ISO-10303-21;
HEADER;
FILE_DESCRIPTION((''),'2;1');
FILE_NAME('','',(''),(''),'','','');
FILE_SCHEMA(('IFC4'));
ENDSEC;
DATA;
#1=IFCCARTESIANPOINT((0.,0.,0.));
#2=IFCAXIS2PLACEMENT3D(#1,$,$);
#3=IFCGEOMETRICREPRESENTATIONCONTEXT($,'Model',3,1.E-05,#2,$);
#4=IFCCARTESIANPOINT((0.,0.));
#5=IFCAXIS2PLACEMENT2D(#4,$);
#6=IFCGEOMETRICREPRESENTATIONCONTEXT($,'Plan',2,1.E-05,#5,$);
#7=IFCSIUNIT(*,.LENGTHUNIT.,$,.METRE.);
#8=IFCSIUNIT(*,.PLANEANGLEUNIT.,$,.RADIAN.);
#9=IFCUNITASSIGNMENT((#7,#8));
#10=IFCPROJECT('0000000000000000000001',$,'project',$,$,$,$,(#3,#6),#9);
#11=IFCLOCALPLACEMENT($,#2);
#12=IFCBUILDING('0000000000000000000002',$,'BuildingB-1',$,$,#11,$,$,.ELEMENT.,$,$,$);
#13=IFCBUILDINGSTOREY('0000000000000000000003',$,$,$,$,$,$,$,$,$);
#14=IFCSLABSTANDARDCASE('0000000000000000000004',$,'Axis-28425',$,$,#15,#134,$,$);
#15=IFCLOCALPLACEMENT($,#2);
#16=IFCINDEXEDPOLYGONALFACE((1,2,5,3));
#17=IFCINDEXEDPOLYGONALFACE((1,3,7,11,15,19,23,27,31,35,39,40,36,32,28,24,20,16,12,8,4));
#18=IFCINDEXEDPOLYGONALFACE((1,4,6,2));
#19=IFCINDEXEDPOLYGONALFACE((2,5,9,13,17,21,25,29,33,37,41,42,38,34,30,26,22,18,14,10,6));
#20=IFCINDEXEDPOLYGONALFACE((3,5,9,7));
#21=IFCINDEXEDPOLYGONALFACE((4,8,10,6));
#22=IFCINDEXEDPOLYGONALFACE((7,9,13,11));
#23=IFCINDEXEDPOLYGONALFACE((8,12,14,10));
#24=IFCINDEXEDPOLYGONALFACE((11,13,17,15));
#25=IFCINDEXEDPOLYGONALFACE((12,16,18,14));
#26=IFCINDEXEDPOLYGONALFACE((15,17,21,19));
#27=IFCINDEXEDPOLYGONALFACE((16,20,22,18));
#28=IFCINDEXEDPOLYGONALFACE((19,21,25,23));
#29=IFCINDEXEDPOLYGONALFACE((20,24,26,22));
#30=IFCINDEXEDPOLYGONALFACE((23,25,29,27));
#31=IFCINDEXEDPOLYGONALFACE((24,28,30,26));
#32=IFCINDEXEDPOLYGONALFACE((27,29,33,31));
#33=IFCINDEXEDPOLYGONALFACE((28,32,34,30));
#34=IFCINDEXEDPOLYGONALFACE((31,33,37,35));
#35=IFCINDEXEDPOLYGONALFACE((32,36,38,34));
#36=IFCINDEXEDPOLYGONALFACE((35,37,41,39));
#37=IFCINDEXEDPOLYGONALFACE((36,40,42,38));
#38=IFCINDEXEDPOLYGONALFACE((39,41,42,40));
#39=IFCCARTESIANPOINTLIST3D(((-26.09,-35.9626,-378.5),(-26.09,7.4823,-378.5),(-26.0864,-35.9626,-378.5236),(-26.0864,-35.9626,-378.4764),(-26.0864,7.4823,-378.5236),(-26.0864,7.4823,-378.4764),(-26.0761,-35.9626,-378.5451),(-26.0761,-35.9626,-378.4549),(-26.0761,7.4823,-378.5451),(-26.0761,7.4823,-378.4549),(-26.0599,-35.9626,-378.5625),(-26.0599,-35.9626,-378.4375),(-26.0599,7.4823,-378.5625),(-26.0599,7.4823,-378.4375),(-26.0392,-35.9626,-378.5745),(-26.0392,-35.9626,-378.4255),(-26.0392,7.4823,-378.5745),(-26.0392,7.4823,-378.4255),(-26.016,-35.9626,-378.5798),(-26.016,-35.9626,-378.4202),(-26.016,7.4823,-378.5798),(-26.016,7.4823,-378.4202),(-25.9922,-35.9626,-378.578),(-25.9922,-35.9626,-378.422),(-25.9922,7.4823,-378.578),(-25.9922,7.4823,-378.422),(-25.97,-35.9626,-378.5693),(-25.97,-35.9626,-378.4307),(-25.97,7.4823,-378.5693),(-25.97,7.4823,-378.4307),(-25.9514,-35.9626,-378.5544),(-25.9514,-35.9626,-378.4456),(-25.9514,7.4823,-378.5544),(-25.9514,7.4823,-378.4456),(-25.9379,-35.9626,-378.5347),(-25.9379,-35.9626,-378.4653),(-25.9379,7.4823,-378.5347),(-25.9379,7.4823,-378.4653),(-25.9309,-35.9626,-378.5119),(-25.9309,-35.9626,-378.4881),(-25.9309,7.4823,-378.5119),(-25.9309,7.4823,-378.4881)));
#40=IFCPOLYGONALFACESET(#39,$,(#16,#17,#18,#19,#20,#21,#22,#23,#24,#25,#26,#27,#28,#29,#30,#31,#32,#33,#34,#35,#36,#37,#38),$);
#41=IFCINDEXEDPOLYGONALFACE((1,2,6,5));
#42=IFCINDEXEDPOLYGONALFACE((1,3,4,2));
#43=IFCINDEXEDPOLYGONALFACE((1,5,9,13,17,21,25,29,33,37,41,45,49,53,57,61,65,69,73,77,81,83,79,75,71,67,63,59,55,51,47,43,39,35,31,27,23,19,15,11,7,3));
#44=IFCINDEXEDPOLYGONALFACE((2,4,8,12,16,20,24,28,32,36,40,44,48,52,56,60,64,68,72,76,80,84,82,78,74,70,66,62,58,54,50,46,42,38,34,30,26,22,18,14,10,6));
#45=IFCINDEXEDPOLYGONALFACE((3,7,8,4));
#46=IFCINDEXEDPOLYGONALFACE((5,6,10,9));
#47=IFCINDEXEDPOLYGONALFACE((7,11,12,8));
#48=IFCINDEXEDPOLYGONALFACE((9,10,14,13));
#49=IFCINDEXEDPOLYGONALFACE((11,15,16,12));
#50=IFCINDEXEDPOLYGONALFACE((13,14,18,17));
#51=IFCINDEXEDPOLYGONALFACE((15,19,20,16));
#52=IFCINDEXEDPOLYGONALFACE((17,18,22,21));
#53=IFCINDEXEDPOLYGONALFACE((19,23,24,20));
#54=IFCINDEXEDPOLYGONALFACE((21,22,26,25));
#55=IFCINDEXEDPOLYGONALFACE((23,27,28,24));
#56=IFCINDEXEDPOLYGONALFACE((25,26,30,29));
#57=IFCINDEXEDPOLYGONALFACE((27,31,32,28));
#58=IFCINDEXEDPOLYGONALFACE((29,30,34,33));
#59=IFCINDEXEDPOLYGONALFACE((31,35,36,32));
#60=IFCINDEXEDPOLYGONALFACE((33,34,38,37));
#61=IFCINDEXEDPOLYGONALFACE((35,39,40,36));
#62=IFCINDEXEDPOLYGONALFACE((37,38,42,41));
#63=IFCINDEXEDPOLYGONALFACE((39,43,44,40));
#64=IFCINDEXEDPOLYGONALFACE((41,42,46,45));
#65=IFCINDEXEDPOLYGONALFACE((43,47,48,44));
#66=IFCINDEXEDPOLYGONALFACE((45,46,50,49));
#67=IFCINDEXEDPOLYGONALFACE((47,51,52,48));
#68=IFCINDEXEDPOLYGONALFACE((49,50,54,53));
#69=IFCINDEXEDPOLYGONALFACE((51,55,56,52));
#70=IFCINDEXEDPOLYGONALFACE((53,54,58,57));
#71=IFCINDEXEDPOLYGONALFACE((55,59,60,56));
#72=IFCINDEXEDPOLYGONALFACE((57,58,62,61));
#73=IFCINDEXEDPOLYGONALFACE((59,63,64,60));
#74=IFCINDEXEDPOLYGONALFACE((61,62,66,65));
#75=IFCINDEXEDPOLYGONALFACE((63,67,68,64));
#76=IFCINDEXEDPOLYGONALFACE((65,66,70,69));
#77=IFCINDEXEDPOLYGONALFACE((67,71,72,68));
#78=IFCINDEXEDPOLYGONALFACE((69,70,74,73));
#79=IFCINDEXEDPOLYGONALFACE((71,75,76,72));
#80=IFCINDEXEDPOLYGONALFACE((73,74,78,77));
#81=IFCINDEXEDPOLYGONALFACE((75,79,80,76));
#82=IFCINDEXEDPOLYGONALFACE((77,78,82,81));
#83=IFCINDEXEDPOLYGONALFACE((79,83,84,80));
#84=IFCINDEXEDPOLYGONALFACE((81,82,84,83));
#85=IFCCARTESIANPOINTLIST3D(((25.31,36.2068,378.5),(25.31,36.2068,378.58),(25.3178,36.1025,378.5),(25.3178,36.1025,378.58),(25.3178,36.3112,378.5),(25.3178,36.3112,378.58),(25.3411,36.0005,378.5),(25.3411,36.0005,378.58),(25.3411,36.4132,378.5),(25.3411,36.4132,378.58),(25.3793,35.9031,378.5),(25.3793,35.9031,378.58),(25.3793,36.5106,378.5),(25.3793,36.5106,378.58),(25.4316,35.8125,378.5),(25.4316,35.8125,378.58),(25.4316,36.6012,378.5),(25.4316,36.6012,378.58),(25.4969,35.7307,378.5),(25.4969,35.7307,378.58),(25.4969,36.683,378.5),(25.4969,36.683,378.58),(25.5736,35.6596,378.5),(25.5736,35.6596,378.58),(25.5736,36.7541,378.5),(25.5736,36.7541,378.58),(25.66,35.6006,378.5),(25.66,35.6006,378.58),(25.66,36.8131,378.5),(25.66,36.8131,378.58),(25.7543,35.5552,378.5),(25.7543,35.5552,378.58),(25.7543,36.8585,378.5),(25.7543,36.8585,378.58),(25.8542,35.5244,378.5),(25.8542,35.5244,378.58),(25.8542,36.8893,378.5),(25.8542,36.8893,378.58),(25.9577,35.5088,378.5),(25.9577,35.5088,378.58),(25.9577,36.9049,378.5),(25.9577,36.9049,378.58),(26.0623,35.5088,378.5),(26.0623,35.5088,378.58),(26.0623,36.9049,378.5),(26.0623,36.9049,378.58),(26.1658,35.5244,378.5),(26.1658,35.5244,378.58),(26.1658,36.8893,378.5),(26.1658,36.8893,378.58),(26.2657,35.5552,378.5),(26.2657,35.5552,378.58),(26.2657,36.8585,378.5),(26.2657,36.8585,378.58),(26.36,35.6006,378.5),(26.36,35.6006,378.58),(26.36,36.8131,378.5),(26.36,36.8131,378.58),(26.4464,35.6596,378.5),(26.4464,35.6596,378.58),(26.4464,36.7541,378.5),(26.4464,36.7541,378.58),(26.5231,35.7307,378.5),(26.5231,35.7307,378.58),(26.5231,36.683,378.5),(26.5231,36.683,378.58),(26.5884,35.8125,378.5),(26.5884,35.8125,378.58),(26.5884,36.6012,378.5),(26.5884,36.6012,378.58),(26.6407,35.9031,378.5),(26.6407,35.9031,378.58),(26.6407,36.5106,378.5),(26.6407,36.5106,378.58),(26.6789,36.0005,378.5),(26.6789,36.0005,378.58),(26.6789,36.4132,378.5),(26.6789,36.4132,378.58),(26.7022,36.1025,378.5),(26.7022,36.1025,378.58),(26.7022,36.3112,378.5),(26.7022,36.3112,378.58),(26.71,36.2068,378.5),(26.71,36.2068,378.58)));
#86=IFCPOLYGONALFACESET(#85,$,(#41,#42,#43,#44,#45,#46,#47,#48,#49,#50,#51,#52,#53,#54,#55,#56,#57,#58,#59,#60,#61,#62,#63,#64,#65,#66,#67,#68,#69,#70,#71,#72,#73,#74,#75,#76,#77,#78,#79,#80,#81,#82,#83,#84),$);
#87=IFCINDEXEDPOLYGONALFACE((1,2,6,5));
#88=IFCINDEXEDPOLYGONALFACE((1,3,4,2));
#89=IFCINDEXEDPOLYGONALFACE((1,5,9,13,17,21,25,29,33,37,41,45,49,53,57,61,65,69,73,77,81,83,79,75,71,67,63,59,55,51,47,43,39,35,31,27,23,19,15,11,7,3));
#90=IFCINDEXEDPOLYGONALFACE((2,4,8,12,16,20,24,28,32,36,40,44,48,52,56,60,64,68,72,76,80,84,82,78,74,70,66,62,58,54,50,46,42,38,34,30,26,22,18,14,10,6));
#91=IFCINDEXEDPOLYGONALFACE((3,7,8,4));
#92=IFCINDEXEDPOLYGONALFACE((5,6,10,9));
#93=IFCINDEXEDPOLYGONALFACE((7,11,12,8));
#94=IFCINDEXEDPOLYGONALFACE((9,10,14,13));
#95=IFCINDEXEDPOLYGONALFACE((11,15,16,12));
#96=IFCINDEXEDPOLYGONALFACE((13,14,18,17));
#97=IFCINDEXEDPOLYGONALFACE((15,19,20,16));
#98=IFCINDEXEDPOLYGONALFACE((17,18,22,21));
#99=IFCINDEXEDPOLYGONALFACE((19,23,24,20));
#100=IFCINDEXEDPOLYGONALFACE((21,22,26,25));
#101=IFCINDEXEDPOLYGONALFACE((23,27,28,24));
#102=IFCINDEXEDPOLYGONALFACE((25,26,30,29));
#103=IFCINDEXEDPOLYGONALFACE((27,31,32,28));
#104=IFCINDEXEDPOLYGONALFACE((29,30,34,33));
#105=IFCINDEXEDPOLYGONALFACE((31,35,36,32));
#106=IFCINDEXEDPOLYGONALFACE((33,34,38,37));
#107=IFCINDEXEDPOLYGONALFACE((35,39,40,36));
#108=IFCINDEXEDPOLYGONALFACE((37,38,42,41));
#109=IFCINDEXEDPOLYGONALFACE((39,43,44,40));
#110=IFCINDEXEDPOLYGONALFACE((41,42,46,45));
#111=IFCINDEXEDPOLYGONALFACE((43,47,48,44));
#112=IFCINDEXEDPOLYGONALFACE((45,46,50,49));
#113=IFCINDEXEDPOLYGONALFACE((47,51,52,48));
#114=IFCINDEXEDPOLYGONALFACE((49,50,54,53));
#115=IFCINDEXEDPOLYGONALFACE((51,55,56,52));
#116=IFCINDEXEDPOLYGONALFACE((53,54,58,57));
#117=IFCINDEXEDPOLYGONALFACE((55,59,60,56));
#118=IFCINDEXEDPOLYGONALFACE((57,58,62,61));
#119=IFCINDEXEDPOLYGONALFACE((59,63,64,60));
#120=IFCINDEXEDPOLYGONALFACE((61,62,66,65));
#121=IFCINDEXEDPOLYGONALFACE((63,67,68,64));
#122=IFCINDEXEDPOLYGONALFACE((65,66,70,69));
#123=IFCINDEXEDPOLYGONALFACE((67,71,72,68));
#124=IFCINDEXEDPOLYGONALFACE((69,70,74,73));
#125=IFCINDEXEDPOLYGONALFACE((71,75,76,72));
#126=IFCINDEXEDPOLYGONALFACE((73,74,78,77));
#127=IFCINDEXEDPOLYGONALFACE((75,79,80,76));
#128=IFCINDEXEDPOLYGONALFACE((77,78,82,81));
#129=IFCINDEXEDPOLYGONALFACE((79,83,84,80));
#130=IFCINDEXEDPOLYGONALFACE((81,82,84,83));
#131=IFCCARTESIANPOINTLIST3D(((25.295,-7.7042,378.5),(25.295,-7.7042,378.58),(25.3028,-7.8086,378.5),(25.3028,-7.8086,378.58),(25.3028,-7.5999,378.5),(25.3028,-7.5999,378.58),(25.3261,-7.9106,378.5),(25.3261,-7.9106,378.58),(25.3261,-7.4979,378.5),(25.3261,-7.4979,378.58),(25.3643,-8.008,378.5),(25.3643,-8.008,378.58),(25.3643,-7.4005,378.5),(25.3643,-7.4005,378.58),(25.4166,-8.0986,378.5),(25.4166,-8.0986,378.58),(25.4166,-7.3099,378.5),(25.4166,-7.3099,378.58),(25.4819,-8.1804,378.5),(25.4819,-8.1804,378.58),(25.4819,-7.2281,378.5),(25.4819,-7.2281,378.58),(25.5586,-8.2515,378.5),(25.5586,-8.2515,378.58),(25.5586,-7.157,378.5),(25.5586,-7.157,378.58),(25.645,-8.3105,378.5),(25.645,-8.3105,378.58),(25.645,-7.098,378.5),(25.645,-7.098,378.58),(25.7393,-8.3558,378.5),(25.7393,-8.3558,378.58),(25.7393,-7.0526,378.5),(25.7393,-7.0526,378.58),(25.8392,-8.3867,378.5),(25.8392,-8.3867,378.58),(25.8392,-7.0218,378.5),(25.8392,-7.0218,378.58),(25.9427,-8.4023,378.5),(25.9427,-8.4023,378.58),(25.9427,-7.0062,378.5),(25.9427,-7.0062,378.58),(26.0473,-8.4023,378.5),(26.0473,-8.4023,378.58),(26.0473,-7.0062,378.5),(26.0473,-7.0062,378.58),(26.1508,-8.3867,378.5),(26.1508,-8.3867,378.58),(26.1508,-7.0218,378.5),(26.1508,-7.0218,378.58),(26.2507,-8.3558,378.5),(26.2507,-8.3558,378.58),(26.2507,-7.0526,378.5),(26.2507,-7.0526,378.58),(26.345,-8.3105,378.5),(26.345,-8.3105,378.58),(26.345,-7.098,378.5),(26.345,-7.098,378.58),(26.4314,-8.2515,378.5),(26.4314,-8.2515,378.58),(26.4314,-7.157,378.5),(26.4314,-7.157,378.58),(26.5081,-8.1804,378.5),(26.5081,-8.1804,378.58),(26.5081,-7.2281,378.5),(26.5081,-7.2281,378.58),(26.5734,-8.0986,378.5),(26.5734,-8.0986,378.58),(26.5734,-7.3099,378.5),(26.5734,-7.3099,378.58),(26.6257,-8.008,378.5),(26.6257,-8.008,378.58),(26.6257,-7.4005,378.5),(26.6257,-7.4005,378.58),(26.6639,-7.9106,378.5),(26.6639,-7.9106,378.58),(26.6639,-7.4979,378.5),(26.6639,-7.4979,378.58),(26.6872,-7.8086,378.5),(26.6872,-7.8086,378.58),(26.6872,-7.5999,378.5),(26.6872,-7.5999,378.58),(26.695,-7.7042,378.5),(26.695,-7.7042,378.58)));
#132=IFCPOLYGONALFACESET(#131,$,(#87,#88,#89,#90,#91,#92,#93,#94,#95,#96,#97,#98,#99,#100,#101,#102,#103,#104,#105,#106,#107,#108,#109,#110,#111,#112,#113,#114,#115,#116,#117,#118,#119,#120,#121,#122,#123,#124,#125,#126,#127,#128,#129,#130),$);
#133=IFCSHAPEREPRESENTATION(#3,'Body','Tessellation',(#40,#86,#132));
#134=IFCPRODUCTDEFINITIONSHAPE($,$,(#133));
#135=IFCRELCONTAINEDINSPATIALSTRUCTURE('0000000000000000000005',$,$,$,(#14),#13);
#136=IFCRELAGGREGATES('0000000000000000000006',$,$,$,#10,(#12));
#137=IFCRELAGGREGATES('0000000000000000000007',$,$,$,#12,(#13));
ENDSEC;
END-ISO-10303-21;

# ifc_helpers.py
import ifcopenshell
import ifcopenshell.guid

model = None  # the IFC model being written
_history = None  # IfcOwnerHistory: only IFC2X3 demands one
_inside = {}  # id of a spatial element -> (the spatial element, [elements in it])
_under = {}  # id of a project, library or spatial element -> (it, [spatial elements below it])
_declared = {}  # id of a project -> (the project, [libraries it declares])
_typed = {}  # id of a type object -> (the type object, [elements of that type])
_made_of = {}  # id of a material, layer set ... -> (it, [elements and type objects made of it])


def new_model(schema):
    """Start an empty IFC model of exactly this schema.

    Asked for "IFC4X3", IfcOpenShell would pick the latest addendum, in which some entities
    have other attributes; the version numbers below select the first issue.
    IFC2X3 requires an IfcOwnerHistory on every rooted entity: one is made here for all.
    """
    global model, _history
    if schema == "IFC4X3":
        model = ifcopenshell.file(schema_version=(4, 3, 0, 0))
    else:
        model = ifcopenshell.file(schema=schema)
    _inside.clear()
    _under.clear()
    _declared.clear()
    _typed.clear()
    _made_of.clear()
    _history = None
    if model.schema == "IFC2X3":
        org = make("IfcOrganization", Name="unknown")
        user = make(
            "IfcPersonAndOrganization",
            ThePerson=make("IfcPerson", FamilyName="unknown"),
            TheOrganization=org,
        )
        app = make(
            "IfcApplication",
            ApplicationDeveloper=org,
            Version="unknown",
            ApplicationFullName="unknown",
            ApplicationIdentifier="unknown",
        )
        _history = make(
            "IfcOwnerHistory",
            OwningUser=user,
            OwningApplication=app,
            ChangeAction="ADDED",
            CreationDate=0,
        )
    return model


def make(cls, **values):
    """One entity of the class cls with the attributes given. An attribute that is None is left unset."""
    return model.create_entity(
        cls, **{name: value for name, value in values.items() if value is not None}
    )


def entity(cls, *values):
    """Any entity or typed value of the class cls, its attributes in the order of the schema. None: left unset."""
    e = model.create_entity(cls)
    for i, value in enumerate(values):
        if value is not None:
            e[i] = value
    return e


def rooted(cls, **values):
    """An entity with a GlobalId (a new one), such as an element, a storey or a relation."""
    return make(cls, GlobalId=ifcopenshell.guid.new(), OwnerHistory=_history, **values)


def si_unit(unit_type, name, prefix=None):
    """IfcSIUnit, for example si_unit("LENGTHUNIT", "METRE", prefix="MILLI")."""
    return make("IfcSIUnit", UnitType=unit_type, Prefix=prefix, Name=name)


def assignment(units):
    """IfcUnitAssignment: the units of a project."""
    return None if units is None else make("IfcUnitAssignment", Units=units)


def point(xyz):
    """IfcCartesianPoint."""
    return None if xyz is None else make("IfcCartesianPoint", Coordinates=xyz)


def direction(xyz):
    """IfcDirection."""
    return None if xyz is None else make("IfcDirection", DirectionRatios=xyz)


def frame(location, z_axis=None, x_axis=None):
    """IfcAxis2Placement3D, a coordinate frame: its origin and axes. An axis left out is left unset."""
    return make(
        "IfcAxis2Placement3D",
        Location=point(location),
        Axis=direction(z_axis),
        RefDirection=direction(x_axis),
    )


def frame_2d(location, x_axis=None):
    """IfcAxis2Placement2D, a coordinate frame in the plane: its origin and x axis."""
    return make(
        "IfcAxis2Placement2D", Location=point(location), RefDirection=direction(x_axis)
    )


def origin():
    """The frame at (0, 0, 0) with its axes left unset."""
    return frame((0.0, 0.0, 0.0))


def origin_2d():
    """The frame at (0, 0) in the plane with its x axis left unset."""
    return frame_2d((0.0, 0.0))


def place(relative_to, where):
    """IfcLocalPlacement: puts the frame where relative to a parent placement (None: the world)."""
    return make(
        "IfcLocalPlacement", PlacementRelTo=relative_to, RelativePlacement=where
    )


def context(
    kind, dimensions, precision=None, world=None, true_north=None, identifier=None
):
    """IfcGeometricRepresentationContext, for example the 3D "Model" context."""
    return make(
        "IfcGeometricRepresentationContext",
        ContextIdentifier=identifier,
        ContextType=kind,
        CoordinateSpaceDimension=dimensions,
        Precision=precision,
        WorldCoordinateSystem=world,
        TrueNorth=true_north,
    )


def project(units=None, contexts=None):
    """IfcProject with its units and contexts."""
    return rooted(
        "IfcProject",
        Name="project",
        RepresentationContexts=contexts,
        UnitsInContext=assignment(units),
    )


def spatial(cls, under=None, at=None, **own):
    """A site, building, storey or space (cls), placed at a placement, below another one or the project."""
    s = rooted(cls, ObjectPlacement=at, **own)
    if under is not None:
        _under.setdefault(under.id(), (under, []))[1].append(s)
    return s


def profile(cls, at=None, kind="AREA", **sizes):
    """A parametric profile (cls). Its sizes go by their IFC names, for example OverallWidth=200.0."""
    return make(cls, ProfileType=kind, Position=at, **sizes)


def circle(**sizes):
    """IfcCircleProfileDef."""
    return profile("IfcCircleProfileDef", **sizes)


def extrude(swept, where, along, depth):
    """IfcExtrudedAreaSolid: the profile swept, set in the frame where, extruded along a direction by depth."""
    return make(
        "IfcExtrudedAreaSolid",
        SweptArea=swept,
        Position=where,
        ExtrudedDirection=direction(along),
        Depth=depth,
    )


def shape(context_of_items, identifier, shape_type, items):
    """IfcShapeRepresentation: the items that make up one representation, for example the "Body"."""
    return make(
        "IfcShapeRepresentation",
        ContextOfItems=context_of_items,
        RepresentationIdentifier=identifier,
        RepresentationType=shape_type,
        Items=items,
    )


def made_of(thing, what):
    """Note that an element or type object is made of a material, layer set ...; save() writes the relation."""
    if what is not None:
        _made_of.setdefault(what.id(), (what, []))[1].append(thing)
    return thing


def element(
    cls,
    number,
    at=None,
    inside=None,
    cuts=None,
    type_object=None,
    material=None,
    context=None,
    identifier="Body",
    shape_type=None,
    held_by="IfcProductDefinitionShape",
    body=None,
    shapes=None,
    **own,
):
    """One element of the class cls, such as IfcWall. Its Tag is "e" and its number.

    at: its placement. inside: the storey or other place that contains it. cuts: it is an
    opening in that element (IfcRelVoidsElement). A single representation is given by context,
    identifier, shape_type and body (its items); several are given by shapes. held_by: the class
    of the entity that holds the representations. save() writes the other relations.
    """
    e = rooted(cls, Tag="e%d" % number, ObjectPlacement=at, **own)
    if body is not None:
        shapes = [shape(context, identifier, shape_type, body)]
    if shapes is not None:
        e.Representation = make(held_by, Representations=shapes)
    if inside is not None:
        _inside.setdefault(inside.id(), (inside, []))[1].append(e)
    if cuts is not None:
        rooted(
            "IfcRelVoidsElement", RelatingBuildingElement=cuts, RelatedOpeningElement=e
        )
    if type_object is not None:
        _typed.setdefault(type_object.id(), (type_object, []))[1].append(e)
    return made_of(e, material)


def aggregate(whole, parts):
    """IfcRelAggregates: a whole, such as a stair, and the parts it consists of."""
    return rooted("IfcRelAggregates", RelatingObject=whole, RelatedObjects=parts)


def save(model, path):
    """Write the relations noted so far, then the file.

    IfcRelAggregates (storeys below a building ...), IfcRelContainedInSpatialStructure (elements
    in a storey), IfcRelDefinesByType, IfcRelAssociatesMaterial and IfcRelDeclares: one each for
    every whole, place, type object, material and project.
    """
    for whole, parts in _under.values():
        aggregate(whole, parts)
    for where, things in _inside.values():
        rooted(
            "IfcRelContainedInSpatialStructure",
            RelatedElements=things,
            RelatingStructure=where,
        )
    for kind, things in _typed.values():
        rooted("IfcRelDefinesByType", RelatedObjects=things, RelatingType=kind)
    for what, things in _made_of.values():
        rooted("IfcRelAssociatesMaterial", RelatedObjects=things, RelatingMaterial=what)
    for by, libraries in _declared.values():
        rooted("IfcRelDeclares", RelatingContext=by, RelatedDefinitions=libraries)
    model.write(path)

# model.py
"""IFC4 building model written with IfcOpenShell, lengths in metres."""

from ifc_helpers import new_model, entity, si_unit, frame, origin, origin_2d, place, context, project, spatial, circle, extrude, element, save


model = new_model("IFC4")

# Units and contexts
model_context = context("Model", 3, precision=1e-05, world=origin())
plan_context = context("Plan", 2, precision=1e-05, world=origin_2d())
ifc_project = project(units=[si_unit("LENGTHUNIT", "METRE"), si_unit("PLANEANGLEUNIT", "RADIAN")], contexts=[model_context, plan_context])

# Building, storey
building_placement = place(None, origin())
building = spatial("IfcBuilding", under=ifc_project, at=building_placement, Name="BuildingB-1", CompositionType="ELEMENT")
storey = spatial("IfcBuildingStorey", under=building)

# Slab
element("IfcSlabStandardCase", 1, inside=storey, Name="Axis-28425", context=model_context, shape_type="AdvancedSweptSolid", body=[
    entity("IfcSurfaceCurveSweptAreaSolid", entity("IfcCircleProfileDef", "AREA", None, None, 0.08), None, entity("IfcPolyline", [entity("IfcCartesianPoint", [26.01, 35.9626, 378.5]), entity("IfcCartesianPoint", [26.01, -7.4823, 378.5])]), None, None, entity("IfcPlane", entity("IfcAxis2Placement3D", entity("IfcCartesianPoint", [26.01, 35.9626, 378.5]), entity("IfcDirection", [0.0, 0.0, 1.0]), entity("IfcDirection", [1.0, 0.0, 0.0])))),
    extrude(circle(Radius=0.7), frame((26.01, 36.2068, 378.5)), (0.0, 0.0, 1.0), 0.08),
    extrude(circle(Radius=0.7), frame((25.995, -7.7042, 378.5)), (0.0, 0.0, 1.0), 0.08),
])

save(model, "model.ifc")
